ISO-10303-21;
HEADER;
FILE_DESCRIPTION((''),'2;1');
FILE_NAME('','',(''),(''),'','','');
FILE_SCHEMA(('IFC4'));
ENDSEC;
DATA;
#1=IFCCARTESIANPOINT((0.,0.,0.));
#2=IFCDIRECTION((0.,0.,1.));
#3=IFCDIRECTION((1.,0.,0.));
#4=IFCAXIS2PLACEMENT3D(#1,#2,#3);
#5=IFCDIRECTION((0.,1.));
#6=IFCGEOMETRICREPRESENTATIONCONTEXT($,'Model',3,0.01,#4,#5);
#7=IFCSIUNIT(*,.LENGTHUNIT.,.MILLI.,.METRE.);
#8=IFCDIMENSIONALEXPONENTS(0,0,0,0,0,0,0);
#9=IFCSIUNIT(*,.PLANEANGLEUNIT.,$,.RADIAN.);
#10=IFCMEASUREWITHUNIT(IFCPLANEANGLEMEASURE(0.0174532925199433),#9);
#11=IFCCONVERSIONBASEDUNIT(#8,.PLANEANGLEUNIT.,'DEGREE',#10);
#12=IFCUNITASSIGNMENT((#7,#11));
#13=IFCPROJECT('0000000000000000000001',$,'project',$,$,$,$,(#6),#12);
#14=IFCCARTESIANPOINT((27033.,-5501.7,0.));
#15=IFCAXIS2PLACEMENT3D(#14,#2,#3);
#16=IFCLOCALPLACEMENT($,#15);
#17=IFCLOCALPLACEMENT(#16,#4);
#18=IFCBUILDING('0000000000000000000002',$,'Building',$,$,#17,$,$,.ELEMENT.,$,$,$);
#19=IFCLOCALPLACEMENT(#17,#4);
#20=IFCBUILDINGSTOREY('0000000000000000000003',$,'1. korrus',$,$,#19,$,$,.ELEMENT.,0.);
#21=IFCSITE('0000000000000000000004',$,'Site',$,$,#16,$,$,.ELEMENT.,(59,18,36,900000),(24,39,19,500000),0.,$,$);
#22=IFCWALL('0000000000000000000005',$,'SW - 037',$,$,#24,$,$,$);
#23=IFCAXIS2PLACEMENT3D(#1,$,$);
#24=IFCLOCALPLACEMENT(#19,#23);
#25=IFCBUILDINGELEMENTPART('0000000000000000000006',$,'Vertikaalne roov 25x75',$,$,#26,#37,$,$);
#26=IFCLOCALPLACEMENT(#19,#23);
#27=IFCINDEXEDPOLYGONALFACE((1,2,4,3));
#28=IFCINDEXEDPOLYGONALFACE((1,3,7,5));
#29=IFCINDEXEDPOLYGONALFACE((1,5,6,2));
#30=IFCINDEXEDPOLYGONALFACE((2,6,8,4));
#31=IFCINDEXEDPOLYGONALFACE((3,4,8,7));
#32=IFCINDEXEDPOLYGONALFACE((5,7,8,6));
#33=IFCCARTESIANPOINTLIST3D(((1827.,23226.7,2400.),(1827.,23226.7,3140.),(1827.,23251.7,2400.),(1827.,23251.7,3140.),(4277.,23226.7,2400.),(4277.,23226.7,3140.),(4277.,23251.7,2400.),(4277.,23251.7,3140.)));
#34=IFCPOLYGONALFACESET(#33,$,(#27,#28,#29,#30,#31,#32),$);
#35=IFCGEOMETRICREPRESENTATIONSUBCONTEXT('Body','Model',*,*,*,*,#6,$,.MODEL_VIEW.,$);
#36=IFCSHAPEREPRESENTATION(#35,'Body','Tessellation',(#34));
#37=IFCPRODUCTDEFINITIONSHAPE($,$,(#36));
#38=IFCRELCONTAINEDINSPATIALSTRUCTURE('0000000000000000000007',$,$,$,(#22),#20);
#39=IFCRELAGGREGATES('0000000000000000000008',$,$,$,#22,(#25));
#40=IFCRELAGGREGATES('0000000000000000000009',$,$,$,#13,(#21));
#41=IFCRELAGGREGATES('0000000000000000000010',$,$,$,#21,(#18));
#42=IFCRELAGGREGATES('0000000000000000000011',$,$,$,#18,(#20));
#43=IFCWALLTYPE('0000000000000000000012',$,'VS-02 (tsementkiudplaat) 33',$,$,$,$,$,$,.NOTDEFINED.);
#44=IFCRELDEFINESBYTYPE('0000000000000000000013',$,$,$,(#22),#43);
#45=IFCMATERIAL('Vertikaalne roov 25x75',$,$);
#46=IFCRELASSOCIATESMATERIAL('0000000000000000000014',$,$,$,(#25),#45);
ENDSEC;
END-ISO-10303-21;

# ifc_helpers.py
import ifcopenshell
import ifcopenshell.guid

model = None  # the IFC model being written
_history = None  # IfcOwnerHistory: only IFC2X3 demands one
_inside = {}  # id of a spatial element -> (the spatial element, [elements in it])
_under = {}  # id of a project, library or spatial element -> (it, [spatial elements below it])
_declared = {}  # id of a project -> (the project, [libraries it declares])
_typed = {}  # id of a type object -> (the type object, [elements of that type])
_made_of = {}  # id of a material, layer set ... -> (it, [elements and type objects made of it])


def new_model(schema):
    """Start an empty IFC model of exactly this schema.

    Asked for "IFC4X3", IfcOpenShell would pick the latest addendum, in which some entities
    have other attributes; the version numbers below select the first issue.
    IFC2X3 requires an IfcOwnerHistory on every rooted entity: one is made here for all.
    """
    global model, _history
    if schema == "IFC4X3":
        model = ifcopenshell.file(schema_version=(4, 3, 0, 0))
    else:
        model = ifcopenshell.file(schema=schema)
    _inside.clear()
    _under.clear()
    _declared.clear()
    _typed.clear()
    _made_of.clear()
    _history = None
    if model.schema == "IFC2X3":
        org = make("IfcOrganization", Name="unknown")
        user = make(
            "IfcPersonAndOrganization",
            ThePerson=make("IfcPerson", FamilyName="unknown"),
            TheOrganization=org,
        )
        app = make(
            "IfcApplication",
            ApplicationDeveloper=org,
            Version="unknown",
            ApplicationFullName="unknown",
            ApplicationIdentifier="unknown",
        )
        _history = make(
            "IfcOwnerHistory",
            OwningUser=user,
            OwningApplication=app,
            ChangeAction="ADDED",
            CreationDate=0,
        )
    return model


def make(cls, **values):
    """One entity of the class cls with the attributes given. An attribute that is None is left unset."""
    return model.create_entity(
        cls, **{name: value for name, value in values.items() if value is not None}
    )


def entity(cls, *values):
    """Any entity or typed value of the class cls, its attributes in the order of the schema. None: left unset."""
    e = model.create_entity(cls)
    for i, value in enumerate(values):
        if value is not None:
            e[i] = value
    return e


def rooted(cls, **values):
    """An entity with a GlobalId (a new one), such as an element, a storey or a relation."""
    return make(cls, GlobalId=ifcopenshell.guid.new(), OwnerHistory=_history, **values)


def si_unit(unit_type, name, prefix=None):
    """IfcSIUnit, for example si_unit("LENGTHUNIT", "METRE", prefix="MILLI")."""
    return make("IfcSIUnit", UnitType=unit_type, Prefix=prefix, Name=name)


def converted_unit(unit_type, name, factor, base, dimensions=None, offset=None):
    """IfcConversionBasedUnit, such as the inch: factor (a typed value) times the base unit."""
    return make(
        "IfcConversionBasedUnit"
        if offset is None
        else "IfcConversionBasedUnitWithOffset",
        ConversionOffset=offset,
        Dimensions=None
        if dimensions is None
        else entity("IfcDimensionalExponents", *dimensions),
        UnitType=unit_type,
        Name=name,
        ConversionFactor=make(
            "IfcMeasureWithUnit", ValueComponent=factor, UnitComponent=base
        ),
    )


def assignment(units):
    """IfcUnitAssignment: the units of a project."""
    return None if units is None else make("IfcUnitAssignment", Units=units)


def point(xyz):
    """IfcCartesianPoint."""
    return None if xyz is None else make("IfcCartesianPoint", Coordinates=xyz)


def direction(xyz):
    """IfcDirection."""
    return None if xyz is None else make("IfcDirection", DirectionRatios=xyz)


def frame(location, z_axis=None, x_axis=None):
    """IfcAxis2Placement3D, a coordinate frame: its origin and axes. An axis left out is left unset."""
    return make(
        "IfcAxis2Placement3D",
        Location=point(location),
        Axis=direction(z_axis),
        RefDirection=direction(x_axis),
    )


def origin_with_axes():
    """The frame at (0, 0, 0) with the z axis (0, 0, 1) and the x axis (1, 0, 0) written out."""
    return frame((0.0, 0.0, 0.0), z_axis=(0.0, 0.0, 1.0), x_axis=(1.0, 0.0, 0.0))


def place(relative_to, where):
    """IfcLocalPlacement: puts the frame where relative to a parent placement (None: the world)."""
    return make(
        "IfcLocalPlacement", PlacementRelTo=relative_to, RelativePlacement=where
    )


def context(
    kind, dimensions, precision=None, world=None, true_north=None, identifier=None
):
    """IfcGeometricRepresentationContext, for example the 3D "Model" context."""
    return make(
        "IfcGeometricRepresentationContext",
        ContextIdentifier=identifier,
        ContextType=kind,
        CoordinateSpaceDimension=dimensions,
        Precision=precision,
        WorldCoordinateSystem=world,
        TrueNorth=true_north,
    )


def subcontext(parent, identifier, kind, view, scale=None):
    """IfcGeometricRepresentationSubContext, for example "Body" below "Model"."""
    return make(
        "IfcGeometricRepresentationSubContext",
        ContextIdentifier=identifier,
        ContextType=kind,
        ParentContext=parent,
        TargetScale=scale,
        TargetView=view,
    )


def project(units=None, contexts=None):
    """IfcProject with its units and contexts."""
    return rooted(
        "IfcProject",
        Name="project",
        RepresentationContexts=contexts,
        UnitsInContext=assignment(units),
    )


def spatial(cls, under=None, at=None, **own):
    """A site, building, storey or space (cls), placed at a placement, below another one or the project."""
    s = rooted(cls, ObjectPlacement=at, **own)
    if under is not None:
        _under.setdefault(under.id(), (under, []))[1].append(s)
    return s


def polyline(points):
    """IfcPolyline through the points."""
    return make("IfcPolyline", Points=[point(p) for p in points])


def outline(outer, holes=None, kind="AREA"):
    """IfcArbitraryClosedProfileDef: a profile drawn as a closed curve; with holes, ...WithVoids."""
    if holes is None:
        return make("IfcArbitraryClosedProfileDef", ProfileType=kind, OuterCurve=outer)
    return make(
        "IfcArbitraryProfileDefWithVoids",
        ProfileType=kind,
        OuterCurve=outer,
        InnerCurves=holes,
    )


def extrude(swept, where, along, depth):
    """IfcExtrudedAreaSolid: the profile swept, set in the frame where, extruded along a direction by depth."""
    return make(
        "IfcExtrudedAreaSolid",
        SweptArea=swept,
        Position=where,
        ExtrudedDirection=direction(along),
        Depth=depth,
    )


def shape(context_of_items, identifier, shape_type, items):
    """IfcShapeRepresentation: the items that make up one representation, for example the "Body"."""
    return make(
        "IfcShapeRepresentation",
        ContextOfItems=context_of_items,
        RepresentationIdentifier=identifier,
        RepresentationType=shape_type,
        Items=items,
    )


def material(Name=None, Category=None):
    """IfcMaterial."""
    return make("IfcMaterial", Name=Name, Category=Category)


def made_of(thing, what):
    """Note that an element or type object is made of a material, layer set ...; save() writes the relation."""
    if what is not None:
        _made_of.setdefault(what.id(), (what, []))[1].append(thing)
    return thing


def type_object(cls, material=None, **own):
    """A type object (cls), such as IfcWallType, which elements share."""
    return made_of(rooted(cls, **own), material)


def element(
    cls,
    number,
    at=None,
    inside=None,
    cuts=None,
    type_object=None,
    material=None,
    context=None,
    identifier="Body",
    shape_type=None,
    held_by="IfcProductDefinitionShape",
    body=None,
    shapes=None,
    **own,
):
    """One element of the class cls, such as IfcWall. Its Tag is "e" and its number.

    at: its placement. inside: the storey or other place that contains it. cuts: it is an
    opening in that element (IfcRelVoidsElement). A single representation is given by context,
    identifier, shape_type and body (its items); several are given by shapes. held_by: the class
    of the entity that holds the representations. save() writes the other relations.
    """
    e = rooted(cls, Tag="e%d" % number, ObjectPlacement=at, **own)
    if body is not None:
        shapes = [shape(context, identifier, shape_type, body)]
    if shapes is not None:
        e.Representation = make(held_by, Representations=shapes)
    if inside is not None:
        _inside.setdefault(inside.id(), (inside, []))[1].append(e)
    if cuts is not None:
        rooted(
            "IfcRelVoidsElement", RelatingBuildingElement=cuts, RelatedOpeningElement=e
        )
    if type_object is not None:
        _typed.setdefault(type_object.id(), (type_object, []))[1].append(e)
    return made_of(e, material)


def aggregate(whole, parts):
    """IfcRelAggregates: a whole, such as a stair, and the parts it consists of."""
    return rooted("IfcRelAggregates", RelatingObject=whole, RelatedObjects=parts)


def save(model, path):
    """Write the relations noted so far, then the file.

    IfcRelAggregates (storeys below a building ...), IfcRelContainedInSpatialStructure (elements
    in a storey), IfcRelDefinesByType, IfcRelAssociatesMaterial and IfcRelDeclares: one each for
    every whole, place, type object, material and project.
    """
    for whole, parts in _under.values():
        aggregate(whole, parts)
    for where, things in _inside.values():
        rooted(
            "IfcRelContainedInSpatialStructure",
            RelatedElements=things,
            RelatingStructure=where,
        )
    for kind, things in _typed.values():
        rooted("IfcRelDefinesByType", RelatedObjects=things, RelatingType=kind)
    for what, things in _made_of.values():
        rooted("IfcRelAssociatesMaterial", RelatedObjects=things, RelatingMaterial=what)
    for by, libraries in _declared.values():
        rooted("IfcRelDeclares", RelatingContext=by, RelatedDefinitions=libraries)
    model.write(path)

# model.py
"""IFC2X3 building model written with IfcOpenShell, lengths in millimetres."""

from ifc_helpers import new_model, entity, si_unit, converted_unit, direction, frame, origin_with_axes, place, context, subcontext, project, spatial, polyline, outline, extrude, material, type_object, element, aggregate, save


model = new_model("IFC2X3")

# Units and contexts
model_context = context("Model", 3, precision=0.01, world=origin_with_axes(), true_north=direction((0.0, 1.0)))
body_context = subcontext(model_context, "Body", "Model", "MODEL_VIEW")
ifc_project = project(units=[si_unit("LENGTHUNIT", "METRE", prefix="MILLI"), converted_unit("PLANEANGLEUNIT", "DEGREE", entity("IfcPlaneAngleMeasure", 0.0174532925199433), si_unit("PLANEANGLEUNIT", "RADIAN"), dimensions=[0, 0, 0, 0, 0, 0, 0])], contexts=[model_context])

# Site, building, storey
site_placement = place(None, frame((27033.0, -5501.7, 0.0), z_axis=(0.0, 0.0, 1.0), x_axis=(1.0, 0.0, 0.0)))
site = spatial("IfcSite", under=ifc_project, at=site_placement, Name="Site", CompositionType="ELEMENT", RefLatitude=(59, 18, 36, 900000), RefLongitude=(24, 39, 19, 500000), RefElevation=0.0)
building_placement = place(site_placement, origin_with_axes())
building = spatial("IfcBuilding", under=site, at=building_placement, Name="Building", CompositionType="ELEMENT")
storey_placement = place(building_placement, origin_with_axes())
storey = spatial("IfcBuildingStorey", under=building, at=storey_placement, Name="1. korrus", CompositionType="ELEMENT", Elevation=0.0)

# Shared definitions
ifc_material_1 = material(Name="Vertikaalne roov 25x75")
wall_type_1 = type_object("IfcWallType", Name="VS-02 (tsementkiudplaat) 33", PredefinedType="NOTDEFINED")

# Wall, building element part
wall_1_placement = place(storey_placement, frame((1827.0, 23226.7, 2400.0), z_axis=(0.0, 0.0, 1.0), x_axis=(1.0, -0.000004, 0.0)))
wall_1 = element("IfcWall", 1, at=wall_1_placement, inside=storey, type_object=wall_type_1, Name="SW - 037")
building_element_part_1_placement = place(wall_1_placement, origin_with_axes())
building_element_part_1 = element("IfcBuildingElementPart", 2, at=building_element_part_1_placement, material=ifc_material_1, Name="Vertikaalne roov 25x75", context=body_context, shape_type="SweptSolid", body=[
    extrude(outline(polyline([(0.0, 0.0), (25.0, 0.0), (25.0, 740.0), (0.0, 740.0), (0.0, 0.0)])), frame((0.0, 0.0, 0.0), z_axis=(1.0, 0.0, 0.0), x_axis=(0.0, 1.0, 0.0)), (0.0, 0.0, 1.0), 2450.0),
])
aggregate(wall_1, [building_element_part_1])

save(model, "model.ifc")
